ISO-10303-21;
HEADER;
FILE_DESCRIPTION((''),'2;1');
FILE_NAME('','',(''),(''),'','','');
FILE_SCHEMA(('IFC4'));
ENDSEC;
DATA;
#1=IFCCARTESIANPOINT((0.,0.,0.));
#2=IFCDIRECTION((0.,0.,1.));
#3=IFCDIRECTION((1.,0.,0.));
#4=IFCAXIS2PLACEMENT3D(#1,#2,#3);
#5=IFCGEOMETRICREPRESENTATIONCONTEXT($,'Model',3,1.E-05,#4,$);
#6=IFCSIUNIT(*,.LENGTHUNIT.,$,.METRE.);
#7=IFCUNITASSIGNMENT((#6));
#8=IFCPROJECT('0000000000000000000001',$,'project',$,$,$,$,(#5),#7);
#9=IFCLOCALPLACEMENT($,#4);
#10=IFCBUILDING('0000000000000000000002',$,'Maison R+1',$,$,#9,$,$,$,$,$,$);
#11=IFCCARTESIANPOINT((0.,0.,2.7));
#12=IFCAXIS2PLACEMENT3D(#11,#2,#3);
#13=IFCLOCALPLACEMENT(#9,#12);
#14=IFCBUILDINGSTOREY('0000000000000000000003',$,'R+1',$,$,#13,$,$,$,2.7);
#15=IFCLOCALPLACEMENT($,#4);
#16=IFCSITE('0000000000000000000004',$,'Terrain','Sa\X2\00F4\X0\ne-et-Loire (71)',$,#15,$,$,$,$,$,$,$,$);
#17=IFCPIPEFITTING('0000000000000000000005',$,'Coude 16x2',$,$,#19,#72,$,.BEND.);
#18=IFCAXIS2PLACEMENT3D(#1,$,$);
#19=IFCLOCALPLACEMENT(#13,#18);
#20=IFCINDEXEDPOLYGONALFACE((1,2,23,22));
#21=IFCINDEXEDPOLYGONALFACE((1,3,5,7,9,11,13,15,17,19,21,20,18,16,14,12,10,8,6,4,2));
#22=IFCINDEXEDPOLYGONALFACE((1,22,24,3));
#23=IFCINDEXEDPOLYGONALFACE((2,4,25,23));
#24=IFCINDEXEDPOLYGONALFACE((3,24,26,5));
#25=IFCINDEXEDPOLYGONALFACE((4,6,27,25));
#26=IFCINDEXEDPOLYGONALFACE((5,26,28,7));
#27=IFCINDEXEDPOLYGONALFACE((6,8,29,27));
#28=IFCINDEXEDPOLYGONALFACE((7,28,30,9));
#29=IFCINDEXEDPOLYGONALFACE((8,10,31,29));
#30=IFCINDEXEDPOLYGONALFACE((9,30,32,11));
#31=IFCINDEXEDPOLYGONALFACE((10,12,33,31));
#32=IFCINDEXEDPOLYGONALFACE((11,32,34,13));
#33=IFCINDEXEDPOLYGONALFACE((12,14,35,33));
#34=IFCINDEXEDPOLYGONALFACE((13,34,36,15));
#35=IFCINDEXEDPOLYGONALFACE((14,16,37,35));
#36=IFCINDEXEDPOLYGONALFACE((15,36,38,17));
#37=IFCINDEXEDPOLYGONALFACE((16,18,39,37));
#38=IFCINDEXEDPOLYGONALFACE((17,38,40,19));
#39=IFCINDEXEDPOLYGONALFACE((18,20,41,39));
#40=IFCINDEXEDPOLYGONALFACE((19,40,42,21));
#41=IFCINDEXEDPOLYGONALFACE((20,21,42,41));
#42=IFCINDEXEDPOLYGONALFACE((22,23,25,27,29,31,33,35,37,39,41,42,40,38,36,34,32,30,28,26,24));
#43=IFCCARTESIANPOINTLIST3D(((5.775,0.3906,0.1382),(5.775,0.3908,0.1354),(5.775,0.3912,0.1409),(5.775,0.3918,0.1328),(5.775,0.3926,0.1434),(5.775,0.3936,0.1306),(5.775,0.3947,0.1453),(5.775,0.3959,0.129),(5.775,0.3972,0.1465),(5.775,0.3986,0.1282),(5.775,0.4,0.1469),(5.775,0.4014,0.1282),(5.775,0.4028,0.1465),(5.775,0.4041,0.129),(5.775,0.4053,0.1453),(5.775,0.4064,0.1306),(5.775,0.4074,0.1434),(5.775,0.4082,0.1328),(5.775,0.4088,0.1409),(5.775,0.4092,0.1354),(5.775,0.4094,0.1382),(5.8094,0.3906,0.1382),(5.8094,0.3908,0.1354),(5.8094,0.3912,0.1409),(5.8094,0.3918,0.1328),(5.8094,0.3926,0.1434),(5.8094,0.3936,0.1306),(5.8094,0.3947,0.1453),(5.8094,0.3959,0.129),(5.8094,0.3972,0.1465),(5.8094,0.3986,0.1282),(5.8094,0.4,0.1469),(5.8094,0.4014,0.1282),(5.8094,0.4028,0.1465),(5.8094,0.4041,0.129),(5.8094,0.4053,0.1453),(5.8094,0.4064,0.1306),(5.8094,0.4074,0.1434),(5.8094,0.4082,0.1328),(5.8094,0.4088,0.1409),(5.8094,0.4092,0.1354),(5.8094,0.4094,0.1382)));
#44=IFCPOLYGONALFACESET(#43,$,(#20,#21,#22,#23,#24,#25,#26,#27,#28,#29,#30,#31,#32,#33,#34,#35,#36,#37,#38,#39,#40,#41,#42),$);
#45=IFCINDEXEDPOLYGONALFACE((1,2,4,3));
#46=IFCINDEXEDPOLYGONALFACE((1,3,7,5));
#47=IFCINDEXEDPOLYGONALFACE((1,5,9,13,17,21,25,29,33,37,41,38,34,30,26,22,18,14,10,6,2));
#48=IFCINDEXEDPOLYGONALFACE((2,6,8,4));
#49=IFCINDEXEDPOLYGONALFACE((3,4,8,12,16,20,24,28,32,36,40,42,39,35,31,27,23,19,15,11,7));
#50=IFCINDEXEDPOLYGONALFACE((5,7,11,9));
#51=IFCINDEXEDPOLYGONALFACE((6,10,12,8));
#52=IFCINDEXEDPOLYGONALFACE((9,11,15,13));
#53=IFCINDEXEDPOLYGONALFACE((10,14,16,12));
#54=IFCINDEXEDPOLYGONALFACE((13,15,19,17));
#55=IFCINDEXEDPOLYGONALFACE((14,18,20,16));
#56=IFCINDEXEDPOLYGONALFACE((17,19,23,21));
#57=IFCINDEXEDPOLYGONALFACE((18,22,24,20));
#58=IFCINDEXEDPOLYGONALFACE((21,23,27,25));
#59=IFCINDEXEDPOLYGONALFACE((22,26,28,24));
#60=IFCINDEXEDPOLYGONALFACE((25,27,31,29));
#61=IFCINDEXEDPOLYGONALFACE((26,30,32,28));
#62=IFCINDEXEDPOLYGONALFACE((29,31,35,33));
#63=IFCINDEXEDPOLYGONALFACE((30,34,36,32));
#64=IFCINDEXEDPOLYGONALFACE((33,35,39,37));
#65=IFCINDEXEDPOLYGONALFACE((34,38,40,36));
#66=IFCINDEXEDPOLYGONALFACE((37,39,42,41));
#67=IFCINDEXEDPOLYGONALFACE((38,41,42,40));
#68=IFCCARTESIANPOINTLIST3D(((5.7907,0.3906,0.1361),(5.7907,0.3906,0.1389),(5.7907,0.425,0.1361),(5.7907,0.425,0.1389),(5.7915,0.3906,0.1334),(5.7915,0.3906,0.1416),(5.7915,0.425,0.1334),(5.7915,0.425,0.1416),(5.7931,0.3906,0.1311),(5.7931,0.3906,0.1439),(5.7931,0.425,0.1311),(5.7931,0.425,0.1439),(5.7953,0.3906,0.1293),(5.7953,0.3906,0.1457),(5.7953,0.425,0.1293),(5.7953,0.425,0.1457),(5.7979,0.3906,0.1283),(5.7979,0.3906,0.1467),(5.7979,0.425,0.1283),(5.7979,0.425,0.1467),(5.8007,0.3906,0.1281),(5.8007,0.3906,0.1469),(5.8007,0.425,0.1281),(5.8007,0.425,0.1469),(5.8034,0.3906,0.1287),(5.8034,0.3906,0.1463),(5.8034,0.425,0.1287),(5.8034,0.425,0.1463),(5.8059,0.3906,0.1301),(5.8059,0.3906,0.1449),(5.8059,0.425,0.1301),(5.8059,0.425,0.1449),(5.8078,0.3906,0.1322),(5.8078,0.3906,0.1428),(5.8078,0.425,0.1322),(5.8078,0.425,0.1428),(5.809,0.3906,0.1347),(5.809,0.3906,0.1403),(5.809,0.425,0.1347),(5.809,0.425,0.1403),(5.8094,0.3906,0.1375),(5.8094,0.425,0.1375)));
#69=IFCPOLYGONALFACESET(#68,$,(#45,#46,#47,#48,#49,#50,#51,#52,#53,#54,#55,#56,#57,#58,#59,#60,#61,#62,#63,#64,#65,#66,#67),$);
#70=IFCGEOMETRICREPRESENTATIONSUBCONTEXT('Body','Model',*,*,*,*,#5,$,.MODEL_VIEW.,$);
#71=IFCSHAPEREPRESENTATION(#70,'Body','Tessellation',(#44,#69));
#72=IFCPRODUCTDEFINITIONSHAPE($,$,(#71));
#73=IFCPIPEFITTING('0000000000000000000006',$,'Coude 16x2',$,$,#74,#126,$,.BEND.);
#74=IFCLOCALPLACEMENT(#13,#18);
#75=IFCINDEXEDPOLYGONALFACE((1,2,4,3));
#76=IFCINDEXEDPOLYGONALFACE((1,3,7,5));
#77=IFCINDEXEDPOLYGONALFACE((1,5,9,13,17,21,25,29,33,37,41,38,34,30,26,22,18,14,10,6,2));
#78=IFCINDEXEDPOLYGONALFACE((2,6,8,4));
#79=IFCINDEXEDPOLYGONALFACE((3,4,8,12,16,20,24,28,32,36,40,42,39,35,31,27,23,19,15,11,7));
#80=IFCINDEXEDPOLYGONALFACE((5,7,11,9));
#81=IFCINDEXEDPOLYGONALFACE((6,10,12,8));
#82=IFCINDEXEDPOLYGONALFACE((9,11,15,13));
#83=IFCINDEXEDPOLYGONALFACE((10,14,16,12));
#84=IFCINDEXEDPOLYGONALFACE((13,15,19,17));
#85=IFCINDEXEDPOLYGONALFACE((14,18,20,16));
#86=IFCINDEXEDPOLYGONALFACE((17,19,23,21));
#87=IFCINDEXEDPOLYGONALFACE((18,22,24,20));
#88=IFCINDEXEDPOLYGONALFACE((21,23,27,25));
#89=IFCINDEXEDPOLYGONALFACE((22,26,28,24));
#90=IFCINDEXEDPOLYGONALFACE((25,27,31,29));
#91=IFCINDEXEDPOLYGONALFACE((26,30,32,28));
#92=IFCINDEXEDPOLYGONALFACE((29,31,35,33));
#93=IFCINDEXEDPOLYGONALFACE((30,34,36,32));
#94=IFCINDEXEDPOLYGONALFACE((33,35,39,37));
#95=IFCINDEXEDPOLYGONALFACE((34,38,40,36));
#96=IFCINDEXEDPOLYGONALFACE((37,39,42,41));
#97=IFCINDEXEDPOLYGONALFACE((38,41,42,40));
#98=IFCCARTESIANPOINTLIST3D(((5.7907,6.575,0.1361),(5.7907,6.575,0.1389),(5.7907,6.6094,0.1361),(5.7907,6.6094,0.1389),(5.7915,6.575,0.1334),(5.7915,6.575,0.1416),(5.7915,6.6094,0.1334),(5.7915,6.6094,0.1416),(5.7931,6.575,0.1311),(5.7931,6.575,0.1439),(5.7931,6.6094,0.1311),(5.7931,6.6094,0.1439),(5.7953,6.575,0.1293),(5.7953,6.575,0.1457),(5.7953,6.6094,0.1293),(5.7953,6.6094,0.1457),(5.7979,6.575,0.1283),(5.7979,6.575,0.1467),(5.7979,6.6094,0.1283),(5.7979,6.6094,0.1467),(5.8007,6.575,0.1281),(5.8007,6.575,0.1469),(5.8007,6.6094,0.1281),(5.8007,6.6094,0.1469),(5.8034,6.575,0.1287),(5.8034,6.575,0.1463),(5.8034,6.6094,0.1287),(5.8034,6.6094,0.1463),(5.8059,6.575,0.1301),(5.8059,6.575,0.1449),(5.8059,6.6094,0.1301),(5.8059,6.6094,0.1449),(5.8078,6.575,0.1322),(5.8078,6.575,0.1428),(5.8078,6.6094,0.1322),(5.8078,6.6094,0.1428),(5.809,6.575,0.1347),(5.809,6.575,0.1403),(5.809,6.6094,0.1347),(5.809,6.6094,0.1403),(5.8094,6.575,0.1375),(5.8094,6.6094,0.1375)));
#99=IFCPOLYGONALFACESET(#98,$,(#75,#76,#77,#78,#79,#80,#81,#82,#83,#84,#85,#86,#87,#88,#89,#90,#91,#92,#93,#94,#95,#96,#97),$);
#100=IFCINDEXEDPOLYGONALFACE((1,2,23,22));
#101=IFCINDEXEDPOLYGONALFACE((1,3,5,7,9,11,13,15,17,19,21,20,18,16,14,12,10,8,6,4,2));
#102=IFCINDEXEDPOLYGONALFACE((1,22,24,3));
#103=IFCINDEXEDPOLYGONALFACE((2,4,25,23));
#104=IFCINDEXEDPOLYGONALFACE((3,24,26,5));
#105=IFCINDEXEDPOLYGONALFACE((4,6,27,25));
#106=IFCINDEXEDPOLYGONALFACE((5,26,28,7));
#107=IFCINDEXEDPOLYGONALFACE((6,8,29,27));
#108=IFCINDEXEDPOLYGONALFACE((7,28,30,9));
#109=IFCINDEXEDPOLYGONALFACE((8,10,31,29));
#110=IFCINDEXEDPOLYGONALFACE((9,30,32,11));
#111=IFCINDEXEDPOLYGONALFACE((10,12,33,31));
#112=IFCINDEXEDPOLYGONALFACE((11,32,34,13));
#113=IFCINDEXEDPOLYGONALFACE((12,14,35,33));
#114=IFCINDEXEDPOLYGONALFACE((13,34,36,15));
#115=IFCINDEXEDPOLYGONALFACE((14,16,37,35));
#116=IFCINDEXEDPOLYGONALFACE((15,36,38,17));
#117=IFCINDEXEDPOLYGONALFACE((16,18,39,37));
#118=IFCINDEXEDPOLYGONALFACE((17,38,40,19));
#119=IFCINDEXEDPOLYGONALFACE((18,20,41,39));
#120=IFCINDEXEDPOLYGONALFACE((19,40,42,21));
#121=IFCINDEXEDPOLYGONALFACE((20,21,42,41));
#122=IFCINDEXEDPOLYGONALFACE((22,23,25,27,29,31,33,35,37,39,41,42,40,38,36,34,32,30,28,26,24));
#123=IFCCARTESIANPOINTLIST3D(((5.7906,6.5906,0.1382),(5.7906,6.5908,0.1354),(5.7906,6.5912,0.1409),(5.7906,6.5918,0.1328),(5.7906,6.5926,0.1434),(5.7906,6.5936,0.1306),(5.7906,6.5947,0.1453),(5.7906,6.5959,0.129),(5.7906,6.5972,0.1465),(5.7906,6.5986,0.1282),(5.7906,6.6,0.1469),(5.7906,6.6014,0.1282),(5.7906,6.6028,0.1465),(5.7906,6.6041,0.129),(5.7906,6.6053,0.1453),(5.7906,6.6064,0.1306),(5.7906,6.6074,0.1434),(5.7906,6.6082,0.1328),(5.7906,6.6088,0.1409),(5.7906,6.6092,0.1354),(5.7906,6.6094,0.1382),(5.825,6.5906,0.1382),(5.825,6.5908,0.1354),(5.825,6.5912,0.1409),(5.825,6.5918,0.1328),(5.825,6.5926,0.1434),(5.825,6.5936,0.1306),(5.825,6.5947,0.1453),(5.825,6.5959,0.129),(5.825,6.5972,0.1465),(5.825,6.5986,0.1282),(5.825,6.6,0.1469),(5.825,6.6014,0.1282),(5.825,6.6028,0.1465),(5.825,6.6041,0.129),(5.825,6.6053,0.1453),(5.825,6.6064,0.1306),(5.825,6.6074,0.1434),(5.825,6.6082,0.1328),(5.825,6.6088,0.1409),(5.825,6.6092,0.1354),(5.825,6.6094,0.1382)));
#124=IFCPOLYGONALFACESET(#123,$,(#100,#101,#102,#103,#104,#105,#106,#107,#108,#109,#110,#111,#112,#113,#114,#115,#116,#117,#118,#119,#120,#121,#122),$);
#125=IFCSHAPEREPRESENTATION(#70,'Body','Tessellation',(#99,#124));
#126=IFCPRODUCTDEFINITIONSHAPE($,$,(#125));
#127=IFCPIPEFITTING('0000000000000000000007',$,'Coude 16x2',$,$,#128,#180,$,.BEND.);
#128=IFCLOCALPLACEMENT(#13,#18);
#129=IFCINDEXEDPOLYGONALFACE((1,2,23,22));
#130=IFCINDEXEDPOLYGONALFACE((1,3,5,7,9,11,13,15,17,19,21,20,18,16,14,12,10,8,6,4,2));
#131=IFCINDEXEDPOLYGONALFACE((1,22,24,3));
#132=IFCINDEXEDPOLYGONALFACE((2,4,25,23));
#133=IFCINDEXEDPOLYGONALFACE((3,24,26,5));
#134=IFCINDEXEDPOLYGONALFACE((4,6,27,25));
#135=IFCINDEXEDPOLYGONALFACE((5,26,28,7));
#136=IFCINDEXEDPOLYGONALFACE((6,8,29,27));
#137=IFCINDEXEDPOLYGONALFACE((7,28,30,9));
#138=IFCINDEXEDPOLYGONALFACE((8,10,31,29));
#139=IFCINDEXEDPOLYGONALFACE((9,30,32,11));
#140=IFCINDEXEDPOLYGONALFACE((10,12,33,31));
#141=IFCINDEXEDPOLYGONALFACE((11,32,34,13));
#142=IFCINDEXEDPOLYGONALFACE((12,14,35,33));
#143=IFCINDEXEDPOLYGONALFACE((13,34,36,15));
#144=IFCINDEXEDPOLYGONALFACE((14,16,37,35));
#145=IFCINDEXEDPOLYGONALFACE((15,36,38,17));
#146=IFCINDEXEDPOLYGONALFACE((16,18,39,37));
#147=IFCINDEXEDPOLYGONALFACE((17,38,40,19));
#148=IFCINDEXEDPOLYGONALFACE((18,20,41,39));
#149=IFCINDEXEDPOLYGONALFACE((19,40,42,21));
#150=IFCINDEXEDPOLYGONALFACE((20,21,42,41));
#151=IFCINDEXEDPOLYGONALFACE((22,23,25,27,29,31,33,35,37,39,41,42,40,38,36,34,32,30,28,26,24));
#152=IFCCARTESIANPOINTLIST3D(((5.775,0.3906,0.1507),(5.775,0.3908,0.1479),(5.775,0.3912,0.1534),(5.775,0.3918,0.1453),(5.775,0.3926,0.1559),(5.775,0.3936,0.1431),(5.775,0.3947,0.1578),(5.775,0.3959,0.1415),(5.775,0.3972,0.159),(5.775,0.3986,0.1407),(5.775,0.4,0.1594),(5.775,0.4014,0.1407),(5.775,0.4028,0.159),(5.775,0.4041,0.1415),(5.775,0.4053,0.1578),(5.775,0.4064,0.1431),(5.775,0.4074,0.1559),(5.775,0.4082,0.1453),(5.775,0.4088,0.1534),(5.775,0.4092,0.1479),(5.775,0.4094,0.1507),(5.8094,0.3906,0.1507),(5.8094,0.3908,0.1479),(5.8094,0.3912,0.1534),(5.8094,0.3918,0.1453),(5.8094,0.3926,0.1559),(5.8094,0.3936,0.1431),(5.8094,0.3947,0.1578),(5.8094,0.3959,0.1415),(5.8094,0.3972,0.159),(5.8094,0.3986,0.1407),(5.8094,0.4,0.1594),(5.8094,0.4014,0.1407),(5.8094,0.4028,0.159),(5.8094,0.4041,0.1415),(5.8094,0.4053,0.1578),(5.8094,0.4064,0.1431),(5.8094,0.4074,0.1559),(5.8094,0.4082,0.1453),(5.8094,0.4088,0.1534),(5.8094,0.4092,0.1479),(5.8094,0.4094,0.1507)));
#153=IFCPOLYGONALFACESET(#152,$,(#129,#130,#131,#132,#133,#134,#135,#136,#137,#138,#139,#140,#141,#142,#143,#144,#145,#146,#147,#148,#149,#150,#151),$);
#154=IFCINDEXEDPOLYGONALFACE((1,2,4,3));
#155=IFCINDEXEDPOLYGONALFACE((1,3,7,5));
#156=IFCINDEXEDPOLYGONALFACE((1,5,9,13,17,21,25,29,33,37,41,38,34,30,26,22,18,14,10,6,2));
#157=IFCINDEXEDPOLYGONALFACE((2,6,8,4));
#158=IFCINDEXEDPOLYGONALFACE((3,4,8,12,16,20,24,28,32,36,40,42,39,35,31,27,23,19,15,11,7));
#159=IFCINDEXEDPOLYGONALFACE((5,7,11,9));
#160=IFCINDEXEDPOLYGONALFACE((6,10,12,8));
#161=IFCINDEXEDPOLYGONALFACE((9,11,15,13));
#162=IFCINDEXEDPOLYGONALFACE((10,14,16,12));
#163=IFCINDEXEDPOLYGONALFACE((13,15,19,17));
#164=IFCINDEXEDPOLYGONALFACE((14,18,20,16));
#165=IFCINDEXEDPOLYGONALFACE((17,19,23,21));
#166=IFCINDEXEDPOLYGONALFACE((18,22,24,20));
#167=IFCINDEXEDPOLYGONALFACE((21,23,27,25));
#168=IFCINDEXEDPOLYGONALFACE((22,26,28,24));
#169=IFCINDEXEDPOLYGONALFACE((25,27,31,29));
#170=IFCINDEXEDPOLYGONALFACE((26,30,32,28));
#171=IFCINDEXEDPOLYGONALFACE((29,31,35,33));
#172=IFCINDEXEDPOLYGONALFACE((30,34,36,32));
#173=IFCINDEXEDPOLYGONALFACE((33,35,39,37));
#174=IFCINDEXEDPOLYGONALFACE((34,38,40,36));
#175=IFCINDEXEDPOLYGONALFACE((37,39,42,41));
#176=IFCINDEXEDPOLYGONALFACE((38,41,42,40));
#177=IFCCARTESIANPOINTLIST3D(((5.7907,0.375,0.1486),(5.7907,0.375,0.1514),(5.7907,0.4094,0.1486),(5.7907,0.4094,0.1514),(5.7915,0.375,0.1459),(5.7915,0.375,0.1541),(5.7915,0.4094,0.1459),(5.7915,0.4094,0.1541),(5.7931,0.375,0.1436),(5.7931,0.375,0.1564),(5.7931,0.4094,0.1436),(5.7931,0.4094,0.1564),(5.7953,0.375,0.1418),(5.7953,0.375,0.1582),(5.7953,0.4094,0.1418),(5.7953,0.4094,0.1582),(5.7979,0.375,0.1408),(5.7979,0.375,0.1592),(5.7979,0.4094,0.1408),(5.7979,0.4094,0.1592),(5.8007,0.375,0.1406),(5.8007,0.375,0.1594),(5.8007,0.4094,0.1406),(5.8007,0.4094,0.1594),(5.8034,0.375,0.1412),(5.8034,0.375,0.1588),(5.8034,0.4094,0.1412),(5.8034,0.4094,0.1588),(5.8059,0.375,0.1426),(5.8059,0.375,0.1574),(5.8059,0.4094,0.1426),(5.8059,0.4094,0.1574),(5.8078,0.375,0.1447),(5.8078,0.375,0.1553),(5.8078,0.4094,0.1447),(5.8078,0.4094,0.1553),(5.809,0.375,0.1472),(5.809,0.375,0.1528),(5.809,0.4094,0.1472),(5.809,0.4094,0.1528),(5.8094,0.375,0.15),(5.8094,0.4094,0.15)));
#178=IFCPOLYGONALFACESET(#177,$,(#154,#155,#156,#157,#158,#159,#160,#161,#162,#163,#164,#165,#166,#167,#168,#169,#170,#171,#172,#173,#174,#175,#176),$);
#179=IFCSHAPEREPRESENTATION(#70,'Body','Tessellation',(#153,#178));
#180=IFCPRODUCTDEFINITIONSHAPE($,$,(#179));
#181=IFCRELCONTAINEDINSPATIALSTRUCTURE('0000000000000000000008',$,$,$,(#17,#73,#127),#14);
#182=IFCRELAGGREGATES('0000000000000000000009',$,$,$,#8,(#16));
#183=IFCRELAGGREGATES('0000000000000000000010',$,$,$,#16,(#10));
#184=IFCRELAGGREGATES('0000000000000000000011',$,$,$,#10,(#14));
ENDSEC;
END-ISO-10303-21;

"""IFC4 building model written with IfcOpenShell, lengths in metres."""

from ifc_helpers import new_model, si_unit, frame, origin_with_axes, place, context, subcontext, project, spatial, circle, extrude, element, save


model = new_model("IFC4")

# Units and contexts
model_context = context("Model", 3, precision=1e-05, world=origin_with_axes())
body_context = subcontext(model_context, "Body", "Model", "MODEL_VIEW")
ifc_project = project(units=[si_unit("LENGTHUNIT", "METRE")], contexts=[model_context])

# Site, building, storey
site_placement = place(None, origin_with_axes())
site = spatial("IfcSite", under=ifc_project, at=site_placement, Name="Terrain", Description="Saône-et-Loire (71)")
building_placement = place(None, origin_with_axes())
building = spatial("IfcBuilding", under=site, at=building_placement, Name="Maison R+1")
storey_placement = place(building_placement, frame((0.0, 0.0, 2.7), z_axis=(0.0, 0.0, 1.0), x_axis=(1.0, 0.0, 0.0)))
storey = spatial("IfcBuildingStorey", under=building, at=storey_placement, Name="R+1", Elevation=2.7)

# Pipe fittings
pipe_fitting_1_placement = place(storey_placement, frame((5.8, 0.4, 0.1375), z_axis=(0.0, 0.0, 1.0), x_axis=(1.0, 0.0, 0.0)))
element("IfcPipeFitting", 1, at=pipe_fitting_1_placement, inside=storey, Name="Coude 16x2", PredefinedType="BEND", context=body_context, shape_type="SweptSolid", body=[
    extrude(circle(Radius=0.0094), frame((0.0094, 0.0, 0.0), z_axis=(-1.0, 0.0, 0.0), x_axis=(0.0, 0.0, 1.0)), (0.0, 0.0, 1.0), 0.0344),
    extrude(circle(Radius=0.0094), frame((0.0, -0.0094, 0.0), z_axis=(0.0, 1.0, 0.0), x_axis=(1.0, 0.0, 0.0)), (0.0, 0.0, 1.0), 0.0344),
])
pipe_fitting_2_placement = place(storey_placement, frame((5.8, 6.6, 0.1375), z_axis=(0.0, 0.0, 1.0), x_axis=(1.0, 0.0, 0.0)))
element("IfcPipeFitting", 2, at=pipe_fitting_2_placement, inside=storey, Name="Coude 16x2", PredefinedType="BEND", context=body_context, shape_type="SweptSolid", body=[
    extrude(circle(Radius=0.0094), frame((0.0, 0.0094, 0.0), z_axis=(0.0, -1.0, 0.0), x_axis=(1.0, 0.0, 0.0)), (0.0, 0.0, 1.0), 0.0344),
    extrude(circle(Radius=0.0094), frame((-0.0094, 0.0, 0.0), z_axis=(1.0, 0.0, 0.0), x_axis=(0.0, 0.0, 1.0)), (0.0, 0.0, 1.0), 0.0344),
])
pipe_fitting_3_placement = place(storey_placement, frame((5.8, 0.4, 0.15), z_axis=(0.0, 0.0, 1.0), x_axis=(1.0, 0.0, 0.0)))
element("IfcPipeFitting", 3, at=pipe_fitting_3_placement, inside=storey, Name="Coude 16x2", PredefinedType="BEND", context=body_context, shape_type="SweptSolid", body=[
    extrude(circle(Radius=0.0094), frame((0.0094, 0.0, 0.0), z_axis=(-1.0, 0.0, 0.0), x_axis=(0.0, 0.0, 1.0)), (0.0, 0.0, 1.0), 0.0344),
    extrude(circle(Radius=0.0094), frame((0.0, 0.0094, 0.0), z_axis=(0.0, -1.0, 0.0), x_axis=(1.0, 0.0, 0.0)), (0.0, 0.0, 1.0), 0.0344),
])

save(model, "model.ifc")
